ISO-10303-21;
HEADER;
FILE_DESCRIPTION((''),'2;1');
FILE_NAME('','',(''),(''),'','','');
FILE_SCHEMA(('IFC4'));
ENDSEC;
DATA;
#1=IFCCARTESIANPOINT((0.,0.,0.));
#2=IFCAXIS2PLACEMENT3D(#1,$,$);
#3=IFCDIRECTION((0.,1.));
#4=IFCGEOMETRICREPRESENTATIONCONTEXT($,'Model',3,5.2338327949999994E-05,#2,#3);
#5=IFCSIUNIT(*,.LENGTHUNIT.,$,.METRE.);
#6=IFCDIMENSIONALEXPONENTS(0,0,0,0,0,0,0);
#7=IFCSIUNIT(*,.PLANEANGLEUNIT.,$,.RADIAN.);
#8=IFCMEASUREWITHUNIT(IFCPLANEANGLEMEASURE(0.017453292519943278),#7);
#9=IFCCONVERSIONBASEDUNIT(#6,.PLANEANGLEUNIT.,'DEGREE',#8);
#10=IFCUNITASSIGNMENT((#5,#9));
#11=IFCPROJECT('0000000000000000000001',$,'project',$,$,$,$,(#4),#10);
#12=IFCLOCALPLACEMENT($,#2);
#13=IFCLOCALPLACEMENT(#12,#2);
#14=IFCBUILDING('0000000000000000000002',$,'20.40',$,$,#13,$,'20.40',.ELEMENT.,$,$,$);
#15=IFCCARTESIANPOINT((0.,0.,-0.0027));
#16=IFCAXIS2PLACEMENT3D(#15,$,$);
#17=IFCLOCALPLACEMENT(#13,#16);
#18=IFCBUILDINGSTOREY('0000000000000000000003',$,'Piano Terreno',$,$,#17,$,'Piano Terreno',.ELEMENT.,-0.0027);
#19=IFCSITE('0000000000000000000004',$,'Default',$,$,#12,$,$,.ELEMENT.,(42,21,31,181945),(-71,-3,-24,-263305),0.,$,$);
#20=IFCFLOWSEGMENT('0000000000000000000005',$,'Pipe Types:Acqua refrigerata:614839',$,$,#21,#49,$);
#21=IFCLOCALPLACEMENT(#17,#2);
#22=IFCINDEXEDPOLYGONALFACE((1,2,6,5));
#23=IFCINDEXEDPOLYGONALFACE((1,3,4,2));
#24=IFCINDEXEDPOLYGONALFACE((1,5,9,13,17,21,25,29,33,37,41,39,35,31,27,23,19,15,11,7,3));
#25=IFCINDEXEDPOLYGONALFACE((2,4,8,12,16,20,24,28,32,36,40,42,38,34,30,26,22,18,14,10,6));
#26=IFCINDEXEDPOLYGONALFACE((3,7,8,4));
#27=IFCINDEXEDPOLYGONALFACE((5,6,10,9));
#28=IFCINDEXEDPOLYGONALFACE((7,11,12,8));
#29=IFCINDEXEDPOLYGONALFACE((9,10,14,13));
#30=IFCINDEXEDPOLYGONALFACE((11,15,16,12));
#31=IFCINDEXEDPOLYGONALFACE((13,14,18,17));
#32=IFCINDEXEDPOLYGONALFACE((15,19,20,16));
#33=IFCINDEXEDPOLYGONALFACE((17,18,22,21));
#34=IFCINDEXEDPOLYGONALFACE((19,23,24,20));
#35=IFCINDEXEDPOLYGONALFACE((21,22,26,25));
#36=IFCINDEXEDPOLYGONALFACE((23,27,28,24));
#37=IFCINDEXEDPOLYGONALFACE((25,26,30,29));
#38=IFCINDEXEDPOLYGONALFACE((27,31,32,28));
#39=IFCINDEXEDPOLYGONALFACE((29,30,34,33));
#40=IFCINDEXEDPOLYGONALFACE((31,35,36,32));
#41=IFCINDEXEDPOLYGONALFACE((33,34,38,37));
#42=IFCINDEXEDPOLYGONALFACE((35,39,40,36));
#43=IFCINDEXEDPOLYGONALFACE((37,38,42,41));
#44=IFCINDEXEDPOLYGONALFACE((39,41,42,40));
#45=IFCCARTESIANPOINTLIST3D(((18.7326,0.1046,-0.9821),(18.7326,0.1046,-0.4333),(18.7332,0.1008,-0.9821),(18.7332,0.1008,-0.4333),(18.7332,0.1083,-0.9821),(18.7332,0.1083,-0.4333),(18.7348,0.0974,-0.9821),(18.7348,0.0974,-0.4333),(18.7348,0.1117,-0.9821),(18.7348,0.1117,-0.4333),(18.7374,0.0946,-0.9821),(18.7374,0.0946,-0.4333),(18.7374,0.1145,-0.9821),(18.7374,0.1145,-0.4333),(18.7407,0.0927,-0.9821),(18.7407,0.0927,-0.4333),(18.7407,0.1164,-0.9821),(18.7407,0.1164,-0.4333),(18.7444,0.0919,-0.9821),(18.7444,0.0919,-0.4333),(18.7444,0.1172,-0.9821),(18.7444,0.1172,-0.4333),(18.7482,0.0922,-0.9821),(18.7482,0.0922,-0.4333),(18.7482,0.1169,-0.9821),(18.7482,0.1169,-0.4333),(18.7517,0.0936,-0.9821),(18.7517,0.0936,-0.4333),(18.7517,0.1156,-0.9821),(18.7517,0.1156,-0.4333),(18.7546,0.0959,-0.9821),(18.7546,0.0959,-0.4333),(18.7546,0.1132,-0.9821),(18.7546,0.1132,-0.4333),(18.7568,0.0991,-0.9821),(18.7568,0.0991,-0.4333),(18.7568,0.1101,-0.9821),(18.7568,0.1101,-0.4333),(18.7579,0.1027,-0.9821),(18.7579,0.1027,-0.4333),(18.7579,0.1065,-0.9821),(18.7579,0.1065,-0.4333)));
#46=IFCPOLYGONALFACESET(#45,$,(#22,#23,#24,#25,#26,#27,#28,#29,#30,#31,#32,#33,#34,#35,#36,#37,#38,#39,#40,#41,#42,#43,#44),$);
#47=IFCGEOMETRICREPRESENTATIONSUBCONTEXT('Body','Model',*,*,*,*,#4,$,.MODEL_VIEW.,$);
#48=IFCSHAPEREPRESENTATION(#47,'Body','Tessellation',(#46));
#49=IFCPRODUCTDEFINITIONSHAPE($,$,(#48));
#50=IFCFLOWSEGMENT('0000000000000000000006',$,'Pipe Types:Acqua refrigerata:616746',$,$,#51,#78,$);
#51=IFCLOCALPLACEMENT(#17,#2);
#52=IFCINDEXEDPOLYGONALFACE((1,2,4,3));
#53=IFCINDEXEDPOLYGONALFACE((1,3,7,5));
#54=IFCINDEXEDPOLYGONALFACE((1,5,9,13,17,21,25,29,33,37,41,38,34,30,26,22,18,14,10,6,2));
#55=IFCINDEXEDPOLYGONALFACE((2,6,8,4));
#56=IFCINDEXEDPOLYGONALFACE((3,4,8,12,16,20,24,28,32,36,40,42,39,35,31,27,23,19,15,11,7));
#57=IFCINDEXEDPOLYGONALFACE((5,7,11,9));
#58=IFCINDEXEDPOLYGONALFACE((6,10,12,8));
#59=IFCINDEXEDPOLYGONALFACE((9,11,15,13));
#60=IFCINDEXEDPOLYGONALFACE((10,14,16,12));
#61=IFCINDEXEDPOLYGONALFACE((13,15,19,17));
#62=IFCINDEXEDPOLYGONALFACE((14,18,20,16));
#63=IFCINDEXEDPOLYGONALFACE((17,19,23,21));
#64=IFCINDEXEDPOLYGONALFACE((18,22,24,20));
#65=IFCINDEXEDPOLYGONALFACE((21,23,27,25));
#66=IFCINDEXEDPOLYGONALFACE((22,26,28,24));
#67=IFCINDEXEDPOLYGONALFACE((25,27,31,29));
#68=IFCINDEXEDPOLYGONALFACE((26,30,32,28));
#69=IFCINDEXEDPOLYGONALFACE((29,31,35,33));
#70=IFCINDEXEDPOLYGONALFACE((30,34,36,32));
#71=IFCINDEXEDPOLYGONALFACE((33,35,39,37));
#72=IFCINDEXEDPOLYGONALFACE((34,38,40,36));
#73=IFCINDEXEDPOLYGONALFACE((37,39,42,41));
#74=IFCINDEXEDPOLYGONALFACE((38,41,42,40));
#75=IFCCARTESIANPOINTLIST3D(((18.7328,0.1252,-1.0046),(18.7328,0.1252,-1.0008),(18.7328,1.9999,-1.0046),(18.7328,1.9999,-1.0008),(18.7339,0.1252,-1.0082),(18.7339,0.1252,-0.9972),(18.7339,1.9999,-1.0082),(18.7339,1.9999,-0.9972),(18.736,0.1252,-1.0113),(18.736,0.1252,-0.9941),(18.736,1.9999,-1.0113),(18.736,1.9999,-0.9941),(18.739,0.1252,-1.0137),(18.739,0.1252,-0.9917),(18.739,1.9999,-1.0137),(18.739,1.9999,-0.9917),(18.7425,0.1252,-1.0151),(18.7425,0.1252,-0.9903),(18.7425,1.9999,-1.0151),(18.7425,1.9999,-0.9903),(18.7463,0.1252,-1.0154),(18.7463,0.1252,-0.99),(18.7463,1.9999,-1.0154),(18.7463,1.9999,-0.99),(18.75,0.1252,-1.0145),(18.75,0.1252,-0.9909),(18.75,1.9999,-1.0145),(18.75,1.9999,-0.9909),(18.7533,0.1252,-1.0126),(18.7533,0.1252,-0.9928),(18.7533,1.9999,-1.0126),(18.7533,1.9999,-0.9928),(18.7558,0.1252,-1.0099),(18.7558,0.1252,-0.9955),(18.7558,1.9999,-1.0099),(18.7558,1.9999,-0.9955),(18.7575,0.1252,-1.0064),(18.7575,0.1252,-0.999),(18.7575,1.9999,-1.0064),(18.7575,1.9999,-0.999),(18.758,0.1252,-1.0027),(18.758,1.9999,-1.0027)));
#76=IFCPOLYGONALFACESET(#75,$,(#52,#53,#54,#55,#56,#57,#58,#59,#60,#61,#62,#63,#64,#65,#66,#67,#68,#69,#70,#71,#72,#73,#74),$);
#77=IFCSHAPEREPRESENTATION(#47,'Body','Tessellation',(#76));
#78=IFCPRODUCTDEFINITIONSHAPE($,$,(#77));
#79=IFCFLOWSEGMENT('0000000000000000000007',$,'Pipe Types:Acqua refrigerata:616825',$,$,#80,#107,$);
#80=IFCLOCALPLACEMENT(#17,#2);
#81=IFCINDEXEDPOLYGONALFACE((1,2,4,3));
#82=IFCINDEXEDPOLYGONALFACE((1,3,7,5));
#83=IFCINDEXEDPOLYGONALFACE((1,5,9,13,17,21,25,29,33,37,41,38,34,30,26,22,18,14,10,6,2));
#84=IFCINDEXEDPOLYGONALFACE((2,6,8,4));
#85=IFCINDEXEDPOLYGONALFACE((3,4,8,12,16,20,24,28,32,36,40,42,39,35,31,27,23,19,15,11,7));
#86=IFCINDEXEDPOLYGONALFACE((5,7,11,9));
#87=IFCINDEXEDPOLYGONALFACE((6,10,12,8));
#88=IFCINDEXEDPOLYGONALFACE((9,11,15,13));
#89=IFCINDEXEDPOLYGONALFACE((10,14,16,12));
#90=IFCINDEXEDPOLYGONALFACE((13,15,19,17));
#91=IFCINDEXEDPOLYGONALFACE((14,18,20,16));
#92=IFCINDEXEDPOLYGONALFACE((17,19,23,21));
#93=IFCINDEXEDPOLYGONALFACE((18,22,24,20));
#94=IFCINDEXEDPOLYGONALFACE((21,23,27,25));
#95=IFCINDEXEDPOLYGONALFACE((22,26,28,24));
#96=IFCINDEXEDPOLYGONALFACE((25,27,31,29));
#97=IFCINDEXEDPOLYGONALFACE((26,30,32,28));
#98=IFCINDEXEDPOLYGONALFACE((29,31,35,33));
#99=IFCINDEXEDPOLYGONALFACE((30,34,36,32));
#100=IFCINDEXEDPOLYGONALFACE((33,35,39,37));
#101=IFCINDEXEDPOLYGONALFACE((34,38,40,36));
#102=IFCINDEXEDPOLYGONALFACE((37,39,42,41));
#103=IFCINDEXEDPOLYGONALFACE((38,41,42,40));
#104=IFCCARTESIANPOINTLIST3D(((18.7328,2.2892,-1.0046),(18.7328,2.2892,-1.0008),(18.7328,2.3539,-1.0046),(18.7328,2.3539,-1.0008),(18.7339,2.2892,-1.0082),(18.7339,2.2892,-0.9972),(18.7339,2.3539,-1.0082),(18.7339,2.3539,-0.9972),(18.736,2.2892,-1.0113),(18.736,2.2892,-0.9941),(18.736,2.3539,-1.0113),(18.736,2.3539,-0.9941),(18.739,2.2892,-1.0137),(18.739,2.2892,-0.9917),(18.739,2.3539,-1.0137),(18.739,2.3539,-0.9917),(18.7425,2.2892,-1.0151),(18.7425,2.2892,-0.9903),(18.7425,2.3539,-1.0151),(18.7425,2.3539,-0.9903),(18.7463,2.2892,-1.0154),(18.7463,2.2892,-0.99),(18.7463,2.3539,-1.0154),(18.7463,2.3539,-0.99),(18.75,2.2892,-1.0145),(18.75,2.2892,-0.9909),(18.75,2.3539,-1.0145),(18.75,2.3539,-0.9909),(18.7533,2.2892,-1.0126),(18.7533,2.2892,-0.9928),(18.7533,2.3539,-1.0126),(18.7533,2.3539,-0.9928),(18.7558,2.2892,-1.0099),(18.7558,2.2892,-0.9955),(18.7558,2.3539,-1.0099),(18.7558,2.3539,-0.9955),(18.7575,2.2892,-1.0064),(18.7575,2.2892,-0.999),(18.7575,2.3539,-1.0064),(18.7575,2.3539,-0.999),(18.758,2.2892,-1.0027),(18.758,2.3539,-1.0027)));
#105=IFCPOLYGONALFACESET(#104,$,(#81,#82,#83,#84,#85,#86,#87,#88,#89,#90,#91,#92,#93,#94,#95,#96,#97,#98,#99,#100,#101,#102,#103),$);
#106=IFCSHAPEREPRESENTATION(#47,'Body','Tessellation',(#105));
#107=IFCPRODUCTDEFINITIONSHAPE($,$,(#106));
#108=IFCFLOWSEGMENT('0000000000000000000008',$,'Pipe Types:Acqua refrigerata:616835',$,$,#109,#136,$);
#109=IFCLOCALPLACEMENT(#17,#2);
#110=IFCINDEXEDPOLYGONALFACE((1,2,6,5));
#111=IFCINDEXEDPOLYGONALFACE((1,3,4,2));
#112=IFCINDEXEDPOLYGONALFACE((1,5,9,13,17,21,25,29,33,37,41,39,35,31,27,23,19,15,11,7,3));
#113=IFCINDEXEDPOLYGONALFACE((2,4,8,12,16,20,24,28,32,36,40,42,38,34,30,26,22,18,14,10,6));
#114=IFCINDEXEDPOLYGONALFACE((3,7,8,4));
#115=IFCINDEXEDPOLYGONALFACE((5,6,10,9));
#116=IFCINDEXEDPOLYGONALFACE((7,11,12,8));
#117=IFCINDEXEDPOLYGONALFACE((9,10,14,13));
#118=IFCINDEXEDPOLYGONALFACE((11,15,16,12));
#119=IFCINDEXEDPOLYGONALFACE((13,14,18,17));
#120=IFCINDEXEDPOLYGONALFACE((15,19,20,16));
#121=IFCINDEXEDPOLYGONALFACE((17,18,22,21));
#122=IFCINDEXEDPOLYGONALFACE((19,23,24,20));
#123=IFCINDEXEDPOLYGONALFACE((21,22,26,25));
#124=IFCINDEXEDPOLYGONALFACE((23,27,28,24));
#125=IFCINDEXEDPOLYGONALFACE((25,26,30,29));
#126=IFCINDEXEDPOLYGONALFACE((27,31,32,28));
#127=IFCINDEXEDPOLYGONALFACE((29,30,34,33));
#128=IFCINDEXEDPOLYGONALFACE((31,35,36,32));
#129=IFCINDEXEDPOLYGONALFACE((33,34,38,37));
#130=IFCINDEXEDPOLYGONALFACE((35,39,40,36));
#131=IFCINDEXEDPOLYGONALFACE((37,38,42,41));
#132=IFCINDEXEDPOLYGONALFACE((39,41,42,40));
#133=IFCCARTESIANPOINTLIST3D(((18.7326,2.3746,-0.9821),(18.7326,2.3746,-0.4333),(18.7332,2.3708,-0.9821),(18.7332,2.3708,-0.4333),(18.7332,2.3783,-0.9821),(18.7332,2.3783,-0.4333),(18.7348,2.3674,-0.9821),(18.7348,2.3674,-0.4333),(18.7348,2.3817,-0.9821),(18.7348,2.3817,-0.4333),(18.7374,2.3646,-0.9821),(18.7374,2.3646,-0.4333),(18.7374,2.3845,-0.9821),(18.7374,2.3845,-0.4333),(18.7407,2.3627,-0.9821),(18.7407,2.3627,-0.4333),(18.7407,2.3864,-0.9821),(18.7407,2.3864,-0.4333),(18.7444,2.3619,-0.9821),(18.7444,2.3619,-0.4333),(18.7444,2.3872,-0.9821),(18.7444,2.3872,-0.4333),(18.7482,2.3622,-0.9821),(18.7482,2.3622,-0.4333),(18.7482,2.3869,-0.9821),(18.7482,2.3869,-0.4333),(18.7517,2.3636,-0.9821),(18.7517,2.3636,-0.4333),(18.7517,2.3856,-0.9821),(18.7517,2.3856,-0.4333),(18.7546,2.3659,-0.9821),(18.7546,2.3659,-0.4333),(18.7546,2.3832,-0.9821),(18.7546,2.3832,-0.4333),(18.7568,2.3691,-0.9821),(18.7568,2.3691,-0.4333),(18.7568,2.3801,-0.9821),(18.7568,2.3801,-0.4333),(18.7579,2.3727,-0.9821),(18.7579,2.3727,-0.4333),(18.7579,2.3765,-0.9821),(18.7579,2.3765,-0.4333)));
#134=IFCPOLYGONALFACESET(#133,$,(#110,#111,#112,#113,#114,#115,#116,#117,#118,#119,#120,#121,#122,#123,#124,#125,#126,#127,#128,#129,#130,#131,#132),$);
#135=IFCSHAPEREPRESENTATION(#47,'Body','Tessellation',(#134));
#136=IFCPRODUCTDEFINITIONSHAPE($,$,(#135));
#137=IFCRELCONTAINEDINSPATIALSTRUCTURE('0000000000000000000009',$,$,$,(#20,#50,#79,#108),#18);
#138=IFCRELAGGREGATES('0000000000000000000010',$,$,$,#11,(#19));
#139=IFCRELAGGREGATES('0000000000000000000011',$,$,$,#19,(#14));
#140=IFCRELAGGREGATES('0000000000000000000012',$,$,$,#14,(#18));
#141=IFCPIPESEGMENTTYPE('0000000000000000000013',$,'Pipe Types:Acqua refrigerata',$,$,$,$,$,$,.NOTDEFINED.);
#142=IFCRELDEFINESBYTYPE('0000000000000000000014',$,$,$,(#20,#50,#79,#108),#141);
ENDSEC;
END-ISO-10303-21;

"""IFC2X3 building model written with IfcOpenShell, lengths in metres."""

from ifc_helpers import new_model, entity, si_unit, converted_unit, direction, frame, frame_2d, origin, origin_2d_with_axis, place, context, subcontext, project, spatial, circle, extrude, type_object, element, save


model = new_model("IFC2X3")

# Units and contexts
model_context = context("Model", 3, precision=5.2338327949999994e-05, world=origin(), true_north=direction((0.0, 1.0)))
body_context = subcontext(model_context, "Body", "Model", "MODEL_VIEW")
ifc_project = project(units=[si_unit("LENGTHUNIT", "METRE"), converted_unit("PLANEANGLEUNIT", "DEGREE", entity("IfcPlaneAngleMeasure", 0.017453292519943278), si_unit("PLANEANGLEUNIT", "RADIAN"), dimensions=[0, 0, 0, 0, 0, 0, 0])], contexts=[model_context])

# Site, building, storey
site_placement = place(None, origin())
site = spatial("IfcSite", under=ifc_project, at=site_placement, Name="Default", CompositionType="ELEMENT", RefLatitude=(42, 21, 31, 181945), RefLongitude=(-71, -3, -24, -263305), RefElevation=0.0)
building_placement = place(site_placement, origin())
building = spatial("IfcBuilding", under=site, at=building_placement, Name="20.40", LongName="20.40", CompositionType="ELEMENT")
storey_placement = place(building_placement, frame((0.0, 0.0, -0.0027)))
storey = spatial("IfcBuildingStorey", under=building, at=storey_placement, Name="Piano Terreno", LongName="Piano Terreno", CompositionType="ELEMENT", Elevation=-0.0027)

# Flow segments
pipe_segment_type = type_object("IfcPipeSegmentType", Name="Pipe Types:Acqua refrigerata", PredefinedType="NOTDEFINED")
flow_segment_1_placement = place(storey_placement, origin())
element("IfcFlowSegment", 1, at=flow_segment_1_placement, inside=storey, type_object=pipe_segment_type, Name="Pipe Types:Acqua refrigerata:614839", context=body_context, shape_type="SweptSolid", body=[
    extrude(circle(Radius=0.0127, at=frame_2d((0.0, 0.0), x_axis=(1.0, 0.0))), frame((18.7453, 0.1046, -0.9821), z_axis=(0.0, 0.0, 1.0), x_axis=(-1.0, 0.0, 0.0)), (0.0, 0.0, 1.0), 0.5487),
])
flow_segment_2_placement = place(storey_placement, origin())
element("IfcFlowSegment", 2, at=flow_segment_2_placement, inside=storey, type_object=pipe_segment_type, Name="Pipe Types:Acqua refrigerata:616746", context=body_context, shape_type="SweptSolid", body=[
    extrude(circle(Radius=0.0127, at=origin_2d_with_axis()), frame((18.7453, 0.1252, -1.0027), z_axis=(0.0, 1.0, 0.0), x_axis=(1.0, 0.0, 0.0)), (0.0, 0.0, 1.0), 1.8747),
])
flow_segment_3_placement = place(storey_placement, origin())
element("IfcFlowSegment", 3, at=flow_segment_3_placement, inside=storey, type_object=pipe_segment_type, Name="Pipe Types:Acqua refrigerata:616825", context=body_context, shape_type="SweptSolid", body=[
    extrude(circle(Radius=0.0127, at=frame_2d((0.0, 0.0), x_axis=(1.0, 0.0))), frame((18.7453, 2.2892, -1.0027), z_axis=(0.0, 1.0, 0.0), x_axis=(1.0, 0.0, 0.0)), (0.0, 0.0, 1.0), 0.0647),
])
flow_segment_4_placement = place(storey_placement, origin())
element("IfcFlowSegment", 4, at=flow_segment_4_placement, inside=storey, type_object=pipe_segment_type, Name="Pipe Types:Acqua refrigerata:616835", context=body_context, shape_type="SweptSolid", body=[
    extrude(circle(Radius=0.0127, at=origin_2d_with_axis()), frame((18.7453, 2.3746, -0.9821), z_axis=(0.0, 0.0, 1.0), x_axis=(-1.0, 0.0, 0.0)), (0.0, 0.0, 1.0), 0.5487),
])

save(model, "model.ifc")
